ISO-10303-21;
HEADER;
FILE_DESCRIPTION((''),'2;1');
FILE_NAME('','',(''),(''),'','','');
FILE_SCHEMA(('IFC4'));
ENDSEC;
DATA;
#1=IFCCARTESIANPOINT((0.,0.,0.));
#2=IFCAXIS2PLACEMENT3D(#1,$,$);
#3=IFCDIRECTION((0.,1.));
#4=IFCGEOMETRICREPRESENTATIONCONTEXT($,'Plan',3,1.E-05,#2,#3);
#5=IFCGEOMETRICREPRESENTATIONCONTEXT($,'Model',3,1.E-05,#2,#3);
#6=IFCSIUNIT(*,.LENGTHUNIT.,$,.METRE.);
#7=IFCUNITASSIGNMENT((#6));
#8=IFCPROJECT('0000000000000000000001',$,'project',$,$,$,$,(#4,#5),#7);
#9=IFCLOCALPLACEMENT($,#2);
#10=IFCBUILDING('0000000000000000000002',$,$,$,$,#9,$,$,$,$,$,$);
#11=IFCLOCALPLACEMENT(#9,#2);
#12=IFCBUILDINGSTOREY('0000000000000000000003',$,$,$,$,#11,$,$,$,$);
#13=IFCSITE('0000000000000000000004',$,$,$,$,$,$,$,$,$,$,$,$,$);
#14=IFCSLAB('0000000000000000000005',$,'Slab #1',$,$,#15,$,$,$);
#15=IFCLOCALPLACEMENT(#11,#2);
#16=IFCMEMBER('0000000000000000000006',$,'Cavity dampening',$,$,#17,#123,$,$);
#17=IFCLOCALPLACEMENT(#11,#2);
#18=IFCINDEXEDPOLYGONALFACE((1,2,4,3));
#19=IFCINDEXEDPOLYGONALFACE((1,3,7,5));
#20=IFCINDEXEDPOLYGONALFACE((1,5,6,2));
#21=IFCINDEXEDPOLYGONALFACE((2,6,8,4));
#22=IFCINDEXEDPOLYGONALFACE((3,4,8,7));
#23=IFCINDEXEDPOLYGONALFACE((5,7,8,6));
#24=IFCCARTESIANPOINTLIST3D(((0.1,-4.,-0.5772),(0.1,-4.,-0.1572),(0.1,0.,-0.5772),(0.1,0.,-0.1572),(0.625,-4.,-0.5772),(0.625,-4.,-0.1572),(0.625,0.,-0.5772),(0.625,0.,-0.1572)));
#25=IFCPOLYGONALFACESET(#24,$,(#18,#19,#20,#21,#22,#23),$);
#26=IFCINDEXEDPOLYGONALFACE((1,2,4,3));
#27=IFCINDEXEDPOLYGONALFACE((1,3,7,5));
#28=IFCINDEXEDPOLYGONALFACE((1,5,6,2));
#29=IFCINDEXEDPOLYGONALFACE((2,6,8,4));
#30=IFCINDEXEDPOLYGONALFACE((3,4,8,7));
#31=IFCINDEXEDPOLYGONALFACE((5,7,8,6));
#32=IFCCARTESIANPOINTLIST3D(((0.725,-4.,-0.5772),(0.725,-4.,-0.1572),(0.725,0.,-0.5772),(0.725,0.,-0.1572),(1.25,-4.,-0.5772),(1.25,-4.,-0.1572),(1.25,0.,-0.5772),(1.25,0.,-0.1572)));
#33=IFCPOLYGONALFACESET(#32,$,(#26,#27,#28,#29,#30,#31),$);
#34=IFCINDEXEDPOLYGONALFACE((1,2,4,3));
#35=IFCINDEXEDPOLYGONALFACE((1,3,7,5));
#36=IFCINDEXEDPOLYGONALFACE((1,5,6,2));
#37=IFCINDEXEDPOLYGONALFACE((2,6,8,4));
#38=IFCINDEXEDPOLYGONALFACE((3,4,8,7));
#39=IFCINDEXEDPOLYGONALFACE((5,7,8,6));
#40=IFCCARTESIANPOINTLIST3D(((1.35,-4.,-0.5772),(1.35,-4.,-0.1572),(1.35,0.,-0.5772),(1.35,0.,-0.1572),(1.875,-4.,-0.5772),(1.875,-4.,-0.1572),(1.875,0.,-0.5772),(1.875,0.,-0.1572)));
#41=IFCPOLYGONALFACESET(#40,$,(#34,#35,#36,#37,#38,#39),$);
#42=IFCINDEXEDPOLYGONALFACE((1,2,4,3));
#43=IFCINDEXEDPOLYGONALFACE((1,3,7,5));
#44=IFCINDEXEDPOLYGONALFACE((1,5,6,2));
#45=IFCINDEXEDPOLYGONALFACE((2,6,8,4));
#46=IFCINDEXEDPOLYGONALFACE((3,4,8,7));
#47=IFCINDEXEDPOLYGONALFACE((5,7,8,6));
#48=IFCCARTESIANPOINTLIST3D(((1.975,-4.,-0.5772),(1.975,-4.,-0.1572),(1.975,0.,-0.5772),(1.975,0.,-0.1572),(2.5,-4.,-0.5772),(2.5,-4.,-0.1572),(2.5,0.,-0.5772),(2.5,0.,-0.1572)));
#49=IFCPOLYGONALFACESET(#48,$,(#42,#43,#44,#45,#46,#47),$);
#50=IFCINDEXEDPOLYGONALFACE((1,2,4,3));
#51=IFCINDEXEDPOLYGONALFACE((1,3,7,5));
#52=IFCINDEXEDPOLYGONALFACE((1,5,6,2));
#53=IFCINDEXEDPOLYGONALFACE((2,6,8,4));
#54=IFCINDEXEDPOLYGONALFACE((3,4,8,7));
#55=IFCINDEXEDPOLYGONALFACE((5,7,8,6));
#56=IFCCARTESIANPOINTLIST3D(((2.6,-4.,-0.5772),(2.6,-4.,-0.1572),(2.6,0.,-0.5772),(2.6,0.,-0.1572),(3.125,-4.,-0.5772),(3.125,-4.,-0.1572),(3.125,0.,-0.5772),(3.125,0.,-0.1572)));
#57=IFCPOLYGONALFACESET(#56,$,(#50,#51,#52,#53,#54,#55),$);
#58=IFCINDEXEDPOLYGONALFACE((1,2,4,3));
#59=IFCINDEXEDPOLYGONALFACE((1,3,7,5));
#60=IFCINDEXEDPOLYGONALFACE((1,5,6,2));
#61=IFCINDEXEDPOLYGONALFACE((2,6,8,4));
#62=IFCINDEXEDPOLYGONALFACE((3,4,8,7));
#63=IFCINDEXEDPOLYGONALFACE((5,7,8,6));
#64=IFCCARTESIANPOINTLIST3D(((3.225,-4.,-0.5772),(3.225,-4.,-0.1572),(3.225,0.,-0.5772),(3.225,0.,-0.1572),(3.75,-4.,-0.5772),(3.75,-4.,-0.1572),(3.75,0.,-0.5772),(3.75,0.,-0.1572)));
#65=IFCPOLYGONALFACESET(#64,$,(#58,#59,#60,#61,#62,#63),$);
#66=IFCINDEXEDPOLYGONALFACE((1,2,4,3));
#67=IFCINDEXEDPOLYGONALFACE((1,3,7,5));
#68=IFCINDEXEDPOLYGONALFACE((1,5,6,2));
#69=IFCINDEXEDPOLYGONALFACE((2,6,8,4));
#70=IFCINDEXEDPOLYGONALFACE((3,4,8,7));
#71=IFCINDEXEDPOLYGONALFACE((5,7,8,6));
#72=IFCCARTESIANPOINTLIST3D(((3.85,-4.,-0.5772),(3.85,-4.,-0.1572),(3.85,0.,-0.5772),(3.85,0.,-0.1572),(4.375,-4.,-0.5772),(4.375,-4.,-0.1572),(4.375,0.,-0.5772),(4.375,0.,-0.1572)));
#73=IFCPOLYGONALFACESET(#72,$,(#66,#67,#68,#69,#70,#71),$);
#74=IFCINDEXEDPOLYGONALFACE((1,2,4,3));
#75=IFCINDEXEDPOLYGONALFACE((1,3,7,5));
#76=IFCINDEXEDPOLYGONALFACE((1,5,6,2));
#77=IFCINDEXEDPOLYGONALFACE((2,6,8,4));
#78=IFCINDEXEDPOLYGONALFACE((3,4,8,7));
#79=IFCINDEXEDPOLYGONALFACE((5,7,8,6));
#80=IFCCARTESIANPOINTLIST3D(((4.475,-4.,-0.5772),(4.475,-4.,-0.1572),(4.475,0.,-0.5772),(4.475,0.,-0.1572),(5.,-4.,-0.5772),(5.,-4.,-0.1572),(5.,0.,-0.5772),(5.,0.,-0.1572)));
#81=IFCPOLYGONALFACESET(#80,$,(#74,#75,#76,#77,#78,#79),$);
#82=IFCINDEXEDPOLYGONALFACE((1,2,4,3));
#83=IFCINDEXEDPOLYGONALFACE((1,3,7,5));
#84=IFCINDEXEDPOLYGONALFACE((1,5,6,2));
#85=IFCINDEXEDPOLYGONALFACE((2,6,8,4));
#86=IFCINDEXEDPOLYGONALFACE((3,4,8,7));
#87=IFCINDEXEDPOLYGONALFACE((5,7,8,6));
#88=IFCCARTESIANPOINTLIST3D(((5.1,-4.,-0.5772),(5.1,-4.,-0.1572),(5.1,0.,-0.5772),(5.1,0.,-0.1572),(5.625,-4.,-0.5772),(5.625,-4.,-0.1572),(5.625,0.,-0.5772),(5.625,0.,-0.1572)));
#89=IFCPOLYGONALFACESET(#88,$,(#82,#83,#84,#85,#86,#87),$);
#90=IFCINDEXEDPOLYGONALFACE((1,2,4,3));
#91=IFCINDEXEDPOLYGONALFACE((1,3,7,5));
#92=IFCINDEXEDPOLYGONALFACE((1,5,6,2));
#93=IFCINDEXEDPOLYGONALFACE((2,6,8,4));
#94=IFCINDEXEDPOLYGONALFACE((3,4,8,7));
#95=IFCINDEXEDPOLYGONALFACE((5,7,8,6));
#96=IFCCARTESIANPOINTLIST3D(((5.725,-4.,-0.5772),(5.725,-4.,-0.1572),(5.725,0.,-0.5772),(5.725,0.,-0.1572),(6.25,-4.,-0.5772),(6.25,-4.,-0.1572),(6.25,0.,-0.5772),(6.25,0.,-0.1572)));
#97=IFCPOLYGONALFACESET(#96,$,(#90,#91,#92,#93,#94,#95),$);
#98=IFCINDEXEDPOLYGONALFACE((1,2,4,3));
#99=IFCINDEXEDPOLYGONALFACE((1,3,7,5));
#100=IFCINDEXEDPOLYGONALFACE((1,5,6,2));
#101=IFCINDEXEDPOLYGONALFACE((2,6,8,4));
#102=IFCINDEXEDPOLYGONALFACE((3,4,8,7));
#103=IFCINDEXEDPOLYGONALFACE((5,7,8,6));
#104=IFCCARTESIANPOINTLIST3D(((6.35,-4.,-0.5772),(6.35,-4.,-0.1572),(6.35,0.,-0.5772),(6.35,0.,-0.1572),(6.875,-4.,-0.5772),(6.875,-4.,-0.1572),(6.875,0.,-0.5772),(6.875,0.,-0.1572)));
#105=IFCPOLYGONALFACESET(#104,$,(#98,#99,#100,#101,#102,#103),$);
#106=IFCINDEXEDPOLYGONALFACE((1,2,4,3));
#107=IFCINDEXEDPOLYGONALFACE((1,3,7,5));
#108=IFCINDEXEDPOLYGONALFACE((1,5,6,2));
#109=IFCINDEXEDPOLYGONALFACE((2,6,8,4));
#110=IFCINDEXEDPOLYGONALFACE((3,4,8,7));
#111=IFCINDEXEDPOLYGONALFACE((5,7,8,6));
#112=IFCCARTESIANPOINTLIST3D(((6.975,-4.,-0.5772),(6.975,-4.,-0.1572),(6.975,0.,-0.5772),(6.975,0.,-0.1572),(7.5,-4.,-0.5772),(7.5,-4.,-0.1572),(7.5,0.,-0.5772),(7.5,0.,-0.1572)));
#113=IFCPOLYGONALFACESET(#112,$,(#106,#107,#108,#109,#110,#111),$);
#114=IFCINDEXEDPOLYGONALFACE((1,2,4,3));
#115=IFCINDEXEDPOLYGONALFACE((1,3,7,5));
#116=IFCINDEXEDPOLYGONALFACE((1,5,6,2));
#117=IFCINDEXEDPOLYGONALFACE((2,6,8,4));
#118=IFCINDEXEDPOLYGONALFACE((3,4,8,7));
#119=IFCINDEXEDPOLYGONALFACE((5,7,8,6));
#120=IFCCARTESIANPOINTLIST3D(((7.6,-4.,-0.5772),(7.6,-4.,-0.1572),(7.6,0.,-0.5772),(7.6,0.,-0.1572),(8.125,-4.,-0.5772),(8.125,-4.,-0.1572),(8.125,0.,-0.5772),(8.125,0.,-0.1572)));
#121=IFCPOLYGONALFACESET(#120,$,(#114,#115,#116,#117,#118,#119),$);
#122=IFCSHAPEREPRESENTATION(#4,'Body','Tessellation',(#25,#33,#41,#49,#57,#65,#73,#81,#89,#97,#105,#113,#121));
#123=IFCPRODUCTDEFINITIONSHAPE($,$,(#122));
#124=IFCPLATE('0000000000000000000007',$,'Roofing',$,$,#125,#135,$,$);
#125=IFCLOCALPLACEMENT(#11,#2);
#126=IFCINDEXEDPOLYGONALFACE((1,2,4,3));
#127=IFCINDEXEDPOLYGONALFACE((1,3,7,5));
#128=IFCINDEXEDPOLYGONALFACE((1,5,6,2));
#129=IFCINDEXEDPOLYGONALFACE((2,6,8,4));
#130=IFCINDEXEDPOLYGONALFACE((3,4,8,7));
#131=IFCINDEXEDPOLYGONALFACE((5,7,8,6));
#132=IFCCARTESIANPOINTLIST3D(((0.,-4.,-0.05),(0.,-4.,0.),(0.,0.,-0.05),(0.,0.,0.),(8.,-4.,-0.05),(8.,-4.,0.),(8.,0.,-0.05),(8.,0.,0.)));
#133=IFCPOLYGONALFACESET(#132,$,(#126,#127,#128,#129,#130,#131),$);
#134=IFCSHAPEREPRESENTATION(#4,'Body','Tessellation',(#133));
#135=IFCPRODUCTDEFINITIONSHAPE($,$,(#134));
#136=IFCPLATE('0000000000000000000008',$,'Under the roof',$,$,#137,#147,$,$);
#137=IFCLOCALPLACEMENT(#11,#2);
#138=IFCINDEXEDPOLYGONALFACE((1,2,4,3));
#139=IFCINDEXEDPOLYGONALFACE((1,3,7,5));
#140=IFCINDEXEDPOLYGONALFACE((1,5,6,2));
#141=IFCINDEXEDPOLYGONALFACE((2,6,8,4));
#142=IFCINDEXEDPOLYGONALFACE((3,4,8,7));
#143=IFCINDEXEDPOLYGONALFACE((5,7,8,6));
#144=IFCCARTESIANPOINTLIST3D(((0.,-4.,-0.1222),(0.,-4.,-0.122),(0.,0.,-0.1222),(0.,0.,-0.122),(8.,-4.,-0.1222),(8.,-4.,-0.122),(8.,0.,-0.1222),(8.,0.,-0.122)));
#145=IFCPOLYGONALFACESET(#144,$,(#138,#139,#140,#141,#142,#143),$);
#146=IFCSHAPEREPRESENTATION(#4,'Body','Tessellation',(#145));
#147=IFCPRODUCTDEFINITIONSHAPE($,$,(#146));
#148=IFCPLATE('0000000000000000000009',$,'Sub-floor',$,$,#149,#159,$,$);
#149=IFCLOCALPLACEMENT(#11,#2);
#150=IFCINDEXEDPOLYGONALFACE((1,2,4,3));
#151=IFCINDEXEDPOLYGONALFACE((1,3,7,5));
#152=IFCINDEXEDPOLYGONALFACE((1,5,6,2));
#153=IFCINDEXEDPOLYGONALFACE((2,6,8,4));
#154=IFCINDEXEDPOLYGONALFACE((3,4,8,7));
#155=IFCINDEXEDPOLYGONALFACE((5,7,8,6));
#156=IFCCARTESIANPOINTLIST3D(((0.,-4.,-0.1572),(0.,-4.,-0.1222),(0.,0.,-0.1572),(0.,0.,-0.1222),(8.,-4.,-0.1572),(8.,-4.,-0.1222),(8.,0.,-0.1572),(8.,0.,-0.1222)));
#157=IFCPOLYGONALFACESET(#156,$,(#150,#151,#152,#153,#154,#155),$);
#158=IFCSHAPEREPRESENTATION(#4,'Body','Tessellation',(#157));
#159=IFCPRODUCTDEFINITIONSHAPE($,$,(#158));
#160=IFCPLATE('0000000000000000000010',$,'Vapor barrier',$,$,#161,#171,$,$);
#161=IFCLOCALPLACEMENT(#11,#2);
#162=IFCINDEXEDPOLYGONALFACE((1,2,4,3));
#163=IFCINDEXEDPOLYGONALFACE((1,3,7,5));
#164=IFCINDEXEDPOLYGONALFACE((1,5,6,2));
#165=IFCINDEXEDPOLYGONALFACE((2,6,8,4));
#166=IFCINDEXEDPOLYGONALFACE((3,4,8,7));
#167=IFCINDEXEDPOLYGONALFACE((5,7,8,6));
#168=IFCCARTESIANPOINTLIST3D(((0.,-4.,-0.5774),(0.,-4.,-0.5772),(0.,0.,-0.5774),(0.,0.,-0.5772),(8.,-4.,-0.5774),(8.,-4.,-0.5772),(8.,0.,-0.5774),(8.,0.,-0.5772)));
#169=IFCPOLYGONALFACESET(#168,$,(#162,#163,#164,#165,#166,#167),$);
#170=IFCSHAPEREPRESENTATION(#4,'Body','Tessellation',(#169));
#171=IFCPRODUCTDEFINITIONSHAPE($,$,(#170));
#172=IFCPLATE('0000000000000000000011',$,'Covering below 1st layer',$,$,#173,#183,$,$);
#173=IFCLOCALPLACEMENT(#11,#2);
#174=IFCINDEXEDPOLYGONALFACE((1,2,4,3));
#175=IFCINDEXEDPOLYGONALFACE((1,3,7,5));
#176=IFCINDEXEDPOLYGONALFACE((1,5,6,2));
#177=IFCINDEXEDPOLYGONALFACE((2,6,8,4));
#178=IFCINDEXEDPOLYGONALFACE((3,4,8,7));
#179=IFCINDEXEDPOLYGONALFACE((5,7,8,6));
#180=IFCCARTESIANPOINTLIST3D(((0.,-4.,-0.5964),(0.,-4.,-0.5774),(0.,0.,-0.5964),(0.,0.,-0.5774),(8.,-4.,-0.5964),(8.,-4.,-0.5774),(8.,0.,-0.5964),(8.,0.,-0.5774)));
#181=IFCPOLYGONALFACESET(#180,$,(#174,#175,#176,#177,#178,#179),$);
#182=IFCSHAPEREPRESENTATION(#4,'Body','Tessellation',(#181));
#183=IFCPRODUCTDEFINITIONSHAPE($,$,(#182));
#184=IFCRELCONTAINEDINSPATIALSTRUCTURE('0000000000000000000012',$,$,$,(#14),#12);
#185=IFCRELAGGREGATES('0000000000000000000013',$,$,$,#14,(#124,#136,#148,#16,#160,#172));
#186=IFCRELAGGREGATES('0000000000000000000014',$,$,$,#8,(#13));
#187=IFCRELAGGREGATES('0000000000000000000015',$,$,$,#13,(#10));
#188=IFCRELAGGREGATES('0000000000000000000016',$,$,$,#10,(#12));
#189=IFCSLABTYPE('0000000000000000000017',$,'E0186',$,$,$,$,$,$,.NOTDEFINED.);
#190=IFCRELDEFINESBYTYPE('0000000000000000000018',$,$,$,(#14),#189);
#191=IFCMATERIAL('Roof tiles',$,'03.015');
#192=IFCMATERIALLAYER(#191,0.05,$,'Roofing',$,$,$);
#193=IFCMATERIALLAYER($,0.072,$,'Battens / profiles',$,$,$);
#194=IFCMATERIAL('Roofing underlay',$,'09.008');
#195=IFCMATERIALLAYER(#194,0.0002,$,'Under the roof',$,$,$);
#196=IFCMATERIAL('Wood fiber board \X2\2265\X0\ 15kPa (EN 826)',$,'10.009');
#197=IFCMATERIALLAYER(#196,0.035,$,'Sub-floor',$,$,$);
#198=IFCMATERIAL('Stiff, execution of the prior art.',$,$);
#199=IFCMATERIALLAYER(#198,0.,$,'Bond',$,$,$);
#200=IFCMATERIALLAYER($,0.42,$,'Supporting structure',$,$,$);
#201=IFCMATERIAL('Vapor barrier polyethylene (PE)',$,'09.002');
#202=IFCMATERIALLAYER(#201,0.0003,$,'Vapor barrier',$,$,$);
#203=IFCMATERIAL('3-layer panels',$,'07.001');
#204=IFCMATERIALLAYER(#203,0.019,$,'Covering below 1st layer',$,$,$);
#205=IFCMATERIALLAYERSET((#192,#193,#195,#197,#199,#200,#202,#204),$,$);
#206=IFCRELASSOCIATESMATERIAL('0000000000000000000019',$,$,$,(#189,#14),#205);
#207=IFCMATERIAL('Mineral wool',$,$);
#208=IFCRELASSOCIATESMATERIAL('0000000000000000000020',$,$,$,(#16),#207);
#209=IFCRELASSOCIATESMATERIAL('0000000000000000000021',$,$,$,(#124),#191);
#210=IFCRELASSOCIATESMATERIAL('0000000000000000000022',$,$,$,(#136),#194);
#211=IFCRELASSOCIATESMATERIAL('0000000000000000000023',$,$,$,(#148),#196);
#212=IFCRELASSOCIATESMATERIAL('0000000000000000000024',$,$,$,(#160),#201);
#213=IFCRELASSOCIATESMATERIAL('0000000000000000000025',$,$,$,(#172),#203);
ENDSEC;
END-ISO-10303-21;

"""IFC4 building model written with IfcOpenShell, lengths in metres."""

from ifc_helpers import new_model, si_unit, direction, frame, frame_2d, origin, origin_with_axes, place, context, project, spatial, rectangle, extrude, material, layer, layer_set, type_object, element, aggregate, save


model = new_model("IFC4")

# Units and contexts
plan_context = context("Plan", 3, precision=1e-05, world=origin(), true_north=direction((0.0, 1.0)))
model_context = context("Model", 3, precision=1e-05, world=origin(), true_north=direction((0.0, 1.0)))
ifc_project = project(units=[si_unit("LENGTHUNIT", "METRE")], contexts=[plan_context, model_context])

# Site, building, storey
site = spatial("IfcSite", under=ifc_project)
building_placement = place(None, origin())
building = spatial("IfcBuilding", under=site, at=building_placement)
storey_placement = place(building_placement, origin())
storey = spatial("IfcBuildingStorey", under=building, at=storey_placement)

# Slab, member, plates
ifc_material_1 = material(Name="Roof tiles", Category="03.015")
ifc_layer_1 = layer(ifc_material_1, 0.05, Name="Roofing")
ifc_layer_2 = layer(None, 0.072, Name="Battens / profiles")
ifc_material_2 = material(Name="Roofing underlay", Category="09.008")
ifc_layer_3 = layer(ifc_material_2, 0.0002, Name="Under the roof")
ifc_material_3 = material(Name="Wood fiber board ≥ 15kPa (EN 826)", Category="10.009")
ifc_layer_4 = layer(ifc_material_3, 0.035, Name="Sub-floor")
ifc_material_4 = material(Name="Stiff, execution of the prior art.")
ifc_layer_5 = layer(ifc_material_4, 0.0, Name="Bond")
ifc_layer_6 = layer(None, 0.42, Name="Supporting structure")
ifc_material_5 = material(Name="Vapor barrier polyethylene (PE)", Category="09.002")
ifc_layer_7 = layer(ifc_material_5, 0.0003, Name="Vapor barrier")
ifc_material_6 = material(Name="3-layer panels", Category="07.001")
ifc_layer_8 = layer(ifc_material_6, 0.019, Name="Covering below 1st layer")
ifc_layer_set = layer_set([ifc_layer_1, ifc_layer_2, ifc_layer_3, ifc_layer_4, ifc_layer_5, ifc_layer_6, ifc_layer_7, ifc_layer_8])
slab_type = type_object("IfcSlabType", Name="E0186", PredefinedType="NOTDEFINED", material=ifc_layer_set)
slab_placement = place(None, frame((0.0, 0.0, 0.0), z_axis=(0.0, 0.0, -1.0), x_axis=(1.0, 0.0, 0.0)))
slab = element("IfcSlab", 1, at=slab_placement, inside=storey, type_object=slab_type, material=ifc_layer_set, Name="Slab #1")
ifc_material_7 = material(Name="Mineral wool")
member_1_placement = place(slab_placement, origin())
member_1 = element("IfcMember", 2, at=member_1_placement, material=ifc_material_7, Name="Cavity dampening", context=plan_context, shape_type="SweptSolid", body=[
    extrude(rectangle(XDim=0.525, YDim=0.42, at=frame_2d((0.2625, 0.21), x_axis=(1.0, 0.0))), frame((0.1, 4.0, 0.1572), z_axis=(0.0, -1.0, 0.0), x_axis=(1.0, 0.0, 0.0)), (0.0, 0.0, 1.0), 4.0),
    extrude(rectangle(XDim=0.525, YDim=0.42, at=frame_2d((0.2625, 0.21), x_axis=(1.0, 0.0))), frame((0.725, 4.0, 0.1572), z_axis=(0.0, -1.0, 0.0), x_axis=(1.0, 0.0, 0.0)), (0.0, 0.0, 1.0), 4.0),
    extrude(rectangle(XDim=0.525, YDim=0.42, at=frame_2d((0.2625, 0.21), x_axis=(1.0, 0.0))), frame((1.35, 4.0, 0.1572), z_axis=(0.0, -1.0, 0.0), x_axis=(1.0, 0.0, 0.0)), (0.0, 0.0, 1.0), 4.0),
    extrude(rectangle(XDim=0.525, YDim=0.42, at=frame_2d((0.2625, 0.21), x_axis=(1.0, 0.0))), frame((1.975, 4.0, 0.1572), z_axis=(0.0, -1.0, 0.0), x_axis=(1.0, 0.0, 0.0)), (0.0, 0.0, 1.0), 4.0),
    extrude(rectangle(XDim=0.525, YDim=0.42, at=frame_2d((0.2625, 0.21), x_axis=(1.0, 0.0))), frame((2.6, 4.0, 0.1572), z_axis=(0.0, -1.0, 0.0), x_axis=(1.0, 0.0, 0.0)), (0.0, 0.0, 1.0), 4.0),
    extrude(rectangle(XDim=0.525, YDim=0.42, at=frame_2d((0.2625, 0.21), x_axis=(1.0, 0.0))), frame((3.225, 4.0, 0.1572), z_axis=(0.0, -1.0, 0.0), x_axis=(1.0, 0.0, 0.0)), (0.0, 0.0, 1.0), 4.0),
    extrude(rectangle(XDim=0.525, YDim=0.42, at=frame_2d((0.2625, 0.21), x_axis=(1.0, 0.0))), frame((3.85, 4.0, 0.1572), z_axis=(0.0, -1.0, 0.0), x_axis=(1.0, 0.0, 0.0)), (0.0, 0.0, 1.0), 4.0),
    extrude(rectangle(XDim=0.525, YDim=0.42, at=frame_2d((0.2625, 0.21), x_axis=(1.0, 0.0))), frame((4.475, 4.0, 0.1572), z_axis=(0.0, -1.0, 0.0), x_axis=(1.0, 0.0, 0.0)), (0.0, 0.0, 1.0), 4.0),
    extrude(rectangle(XDim=0.525, YDim=0.42, at=frame_2d((0.2625, 0.21), x_axis=(1.0, 0.0))), frame((5.1, 4.0, 0.1572), z_axis=(0.0, -1.0, 0.0), x_axis=(1.0, 0.0, 0.0)), (0.0, 0.0, 1.0), 4.0),
    extrude(rectangle(XDim=0.525, YDim=0.42, at=frame_2d((0.2625, 0.21), x_axis=(1.0, 0.0))), frame((5.725, 4.0, 0.1572), z_axis=(0.0, -1.0, 0.0), x_axis=(1.0, 0.0, 0.0)), (0.0, 0.0, 1.0), 4.0),
    extrude(rectangle(XDim=0.525, YDim=0.42, at=frame_2d((0.2625, 0.21), x_axis=(1.0, 0.0))), frame((6.35, 4.0, 0.1572), z_axis=(0.0, -1.0, 0.0), x_axis=(1.0, 0.0, 0.0)), (0.0, 0.0, 1.0), 4.0),
    extrude(rectangle(XDim=0.525, YDim=0.42, at=frame_2d((0.2625, 0.21), x_axis=(1.0, 0.0))), frame((6.975, 4.0, 0.1572), z_axis=(0.0, -1.0, 0.0), x_axis=(1.0, 0.0, 0.0)), (0.0, 0.0, 1.0), 4.0),
    extrude(rectangle(XDim=0.525, YDim=0.42, at=frame_2d((0.2625, 0.21), x_axis=(1.0, 0.0))), frame((7.6, 4.0, 0.1572), z_axis=(0.0, -1.0, 0.0), x_axis=(1.0, 0.0, 0.0)), (0.0, 0.0, 1.0), 4.0),
])
plate_1_placement = place(slab_placement, origin())
plate_1 = element("IfcPlate", 3, at=plate_1_placement, material=ifc_material_1, Name="Roofing", context=plan_context, shape_type="SweptSolid", body=[
    extrude(rectangle(XDim=8.0, YDim=4.0, at=frame_2d((4.0, 2.0), x_axis=(1.0, 0.0))), origin_with_axes(), (0.0, 0.0, 1.0), 0.05),
])
plate_2_placement = place(slab_placement, origin())
plate_2 = element("IfcPlate", 4, at=plate_2_placement, material=ifc_material_2, Name="Under the roof", context=plan_context, shape_type="SweptSolid", body=[
    extrude(rectangle(XDim=8.0, YDim=4.0, at=frame_2d((4.0, 2.0), x_axis=(1.0, 0.0))), frame((0.0, 0.0, 0.122), z_axis=(0.0, 0.0, 1.0), x_axis=(1.0, 0.0, 0.0)), (0.0, 0.0, 1.0), 0.0002),
])
plate_3_placement = place(slab_placement, origin())
plate_3 = element("IfcPlate", 5, at=plate_3_placement, material=ifc_material_3, Name="Sub-floor", context=plan_context, shape_type="SweptSolid", body=[
    extrude(rectangle(XDim=8.0, YDim=4.0, at=frame_2d((4.0, 2.0), x_axis=(1.0, 0.0))), frame((0.0, 0.0, 0.1222), z_axis=(0.0, 0.0, 1.0), x_axis=(1.0, 0.0, 0.0)), (0.0, 0.0, 1.0), 0.035),
])
plate_4_placement = place(slab_placement, origin())
plate_4 = element("IfcPlate", 6, at=plate_4_placement, material=ifc_material_5, Name="Vapor barrier", context=plan_context, shape_type="SweptSolid", body=[
    extrude(rectangle(XDim=8.0, YDim=4.0, at=frame_2d((4.0, 2.0), x_axis=(1.0, 0.0))), frame((0.0, 0.0, 0.5772), z_axis=(0.0, 0.0, 1.0), x_axis=(1.0, 0.0, 0.0)), (0.0, 0.0, 1.0), 0.0003),
])
plate_5_placement = place(slab_placement, origin())
plate_5 = element("IfcPlate", 7, at=plate_5_placement, material=ifc_material_6, Name="Covering below 1st layer", context=plan_context, shape_type="SweptSolid", body=[
    extrude(rectangle(XDim=8.0, YDim=4.0, at=frame_2d((4.0, 2.0), x_axis=(1.0, 0.0))), frame((0.0, 0.0, 0.5774), z_axis=(0.0, 0.0, 1.0), x_axis=(1.0, 0.0, 0.0)), (0.0, 0.0, 1.0), 0.019),
])
aggregate(slab, [plate_1, plate_2, plate_3, member_1, plate_4, plate_5])

save(model, "model.ifc")
